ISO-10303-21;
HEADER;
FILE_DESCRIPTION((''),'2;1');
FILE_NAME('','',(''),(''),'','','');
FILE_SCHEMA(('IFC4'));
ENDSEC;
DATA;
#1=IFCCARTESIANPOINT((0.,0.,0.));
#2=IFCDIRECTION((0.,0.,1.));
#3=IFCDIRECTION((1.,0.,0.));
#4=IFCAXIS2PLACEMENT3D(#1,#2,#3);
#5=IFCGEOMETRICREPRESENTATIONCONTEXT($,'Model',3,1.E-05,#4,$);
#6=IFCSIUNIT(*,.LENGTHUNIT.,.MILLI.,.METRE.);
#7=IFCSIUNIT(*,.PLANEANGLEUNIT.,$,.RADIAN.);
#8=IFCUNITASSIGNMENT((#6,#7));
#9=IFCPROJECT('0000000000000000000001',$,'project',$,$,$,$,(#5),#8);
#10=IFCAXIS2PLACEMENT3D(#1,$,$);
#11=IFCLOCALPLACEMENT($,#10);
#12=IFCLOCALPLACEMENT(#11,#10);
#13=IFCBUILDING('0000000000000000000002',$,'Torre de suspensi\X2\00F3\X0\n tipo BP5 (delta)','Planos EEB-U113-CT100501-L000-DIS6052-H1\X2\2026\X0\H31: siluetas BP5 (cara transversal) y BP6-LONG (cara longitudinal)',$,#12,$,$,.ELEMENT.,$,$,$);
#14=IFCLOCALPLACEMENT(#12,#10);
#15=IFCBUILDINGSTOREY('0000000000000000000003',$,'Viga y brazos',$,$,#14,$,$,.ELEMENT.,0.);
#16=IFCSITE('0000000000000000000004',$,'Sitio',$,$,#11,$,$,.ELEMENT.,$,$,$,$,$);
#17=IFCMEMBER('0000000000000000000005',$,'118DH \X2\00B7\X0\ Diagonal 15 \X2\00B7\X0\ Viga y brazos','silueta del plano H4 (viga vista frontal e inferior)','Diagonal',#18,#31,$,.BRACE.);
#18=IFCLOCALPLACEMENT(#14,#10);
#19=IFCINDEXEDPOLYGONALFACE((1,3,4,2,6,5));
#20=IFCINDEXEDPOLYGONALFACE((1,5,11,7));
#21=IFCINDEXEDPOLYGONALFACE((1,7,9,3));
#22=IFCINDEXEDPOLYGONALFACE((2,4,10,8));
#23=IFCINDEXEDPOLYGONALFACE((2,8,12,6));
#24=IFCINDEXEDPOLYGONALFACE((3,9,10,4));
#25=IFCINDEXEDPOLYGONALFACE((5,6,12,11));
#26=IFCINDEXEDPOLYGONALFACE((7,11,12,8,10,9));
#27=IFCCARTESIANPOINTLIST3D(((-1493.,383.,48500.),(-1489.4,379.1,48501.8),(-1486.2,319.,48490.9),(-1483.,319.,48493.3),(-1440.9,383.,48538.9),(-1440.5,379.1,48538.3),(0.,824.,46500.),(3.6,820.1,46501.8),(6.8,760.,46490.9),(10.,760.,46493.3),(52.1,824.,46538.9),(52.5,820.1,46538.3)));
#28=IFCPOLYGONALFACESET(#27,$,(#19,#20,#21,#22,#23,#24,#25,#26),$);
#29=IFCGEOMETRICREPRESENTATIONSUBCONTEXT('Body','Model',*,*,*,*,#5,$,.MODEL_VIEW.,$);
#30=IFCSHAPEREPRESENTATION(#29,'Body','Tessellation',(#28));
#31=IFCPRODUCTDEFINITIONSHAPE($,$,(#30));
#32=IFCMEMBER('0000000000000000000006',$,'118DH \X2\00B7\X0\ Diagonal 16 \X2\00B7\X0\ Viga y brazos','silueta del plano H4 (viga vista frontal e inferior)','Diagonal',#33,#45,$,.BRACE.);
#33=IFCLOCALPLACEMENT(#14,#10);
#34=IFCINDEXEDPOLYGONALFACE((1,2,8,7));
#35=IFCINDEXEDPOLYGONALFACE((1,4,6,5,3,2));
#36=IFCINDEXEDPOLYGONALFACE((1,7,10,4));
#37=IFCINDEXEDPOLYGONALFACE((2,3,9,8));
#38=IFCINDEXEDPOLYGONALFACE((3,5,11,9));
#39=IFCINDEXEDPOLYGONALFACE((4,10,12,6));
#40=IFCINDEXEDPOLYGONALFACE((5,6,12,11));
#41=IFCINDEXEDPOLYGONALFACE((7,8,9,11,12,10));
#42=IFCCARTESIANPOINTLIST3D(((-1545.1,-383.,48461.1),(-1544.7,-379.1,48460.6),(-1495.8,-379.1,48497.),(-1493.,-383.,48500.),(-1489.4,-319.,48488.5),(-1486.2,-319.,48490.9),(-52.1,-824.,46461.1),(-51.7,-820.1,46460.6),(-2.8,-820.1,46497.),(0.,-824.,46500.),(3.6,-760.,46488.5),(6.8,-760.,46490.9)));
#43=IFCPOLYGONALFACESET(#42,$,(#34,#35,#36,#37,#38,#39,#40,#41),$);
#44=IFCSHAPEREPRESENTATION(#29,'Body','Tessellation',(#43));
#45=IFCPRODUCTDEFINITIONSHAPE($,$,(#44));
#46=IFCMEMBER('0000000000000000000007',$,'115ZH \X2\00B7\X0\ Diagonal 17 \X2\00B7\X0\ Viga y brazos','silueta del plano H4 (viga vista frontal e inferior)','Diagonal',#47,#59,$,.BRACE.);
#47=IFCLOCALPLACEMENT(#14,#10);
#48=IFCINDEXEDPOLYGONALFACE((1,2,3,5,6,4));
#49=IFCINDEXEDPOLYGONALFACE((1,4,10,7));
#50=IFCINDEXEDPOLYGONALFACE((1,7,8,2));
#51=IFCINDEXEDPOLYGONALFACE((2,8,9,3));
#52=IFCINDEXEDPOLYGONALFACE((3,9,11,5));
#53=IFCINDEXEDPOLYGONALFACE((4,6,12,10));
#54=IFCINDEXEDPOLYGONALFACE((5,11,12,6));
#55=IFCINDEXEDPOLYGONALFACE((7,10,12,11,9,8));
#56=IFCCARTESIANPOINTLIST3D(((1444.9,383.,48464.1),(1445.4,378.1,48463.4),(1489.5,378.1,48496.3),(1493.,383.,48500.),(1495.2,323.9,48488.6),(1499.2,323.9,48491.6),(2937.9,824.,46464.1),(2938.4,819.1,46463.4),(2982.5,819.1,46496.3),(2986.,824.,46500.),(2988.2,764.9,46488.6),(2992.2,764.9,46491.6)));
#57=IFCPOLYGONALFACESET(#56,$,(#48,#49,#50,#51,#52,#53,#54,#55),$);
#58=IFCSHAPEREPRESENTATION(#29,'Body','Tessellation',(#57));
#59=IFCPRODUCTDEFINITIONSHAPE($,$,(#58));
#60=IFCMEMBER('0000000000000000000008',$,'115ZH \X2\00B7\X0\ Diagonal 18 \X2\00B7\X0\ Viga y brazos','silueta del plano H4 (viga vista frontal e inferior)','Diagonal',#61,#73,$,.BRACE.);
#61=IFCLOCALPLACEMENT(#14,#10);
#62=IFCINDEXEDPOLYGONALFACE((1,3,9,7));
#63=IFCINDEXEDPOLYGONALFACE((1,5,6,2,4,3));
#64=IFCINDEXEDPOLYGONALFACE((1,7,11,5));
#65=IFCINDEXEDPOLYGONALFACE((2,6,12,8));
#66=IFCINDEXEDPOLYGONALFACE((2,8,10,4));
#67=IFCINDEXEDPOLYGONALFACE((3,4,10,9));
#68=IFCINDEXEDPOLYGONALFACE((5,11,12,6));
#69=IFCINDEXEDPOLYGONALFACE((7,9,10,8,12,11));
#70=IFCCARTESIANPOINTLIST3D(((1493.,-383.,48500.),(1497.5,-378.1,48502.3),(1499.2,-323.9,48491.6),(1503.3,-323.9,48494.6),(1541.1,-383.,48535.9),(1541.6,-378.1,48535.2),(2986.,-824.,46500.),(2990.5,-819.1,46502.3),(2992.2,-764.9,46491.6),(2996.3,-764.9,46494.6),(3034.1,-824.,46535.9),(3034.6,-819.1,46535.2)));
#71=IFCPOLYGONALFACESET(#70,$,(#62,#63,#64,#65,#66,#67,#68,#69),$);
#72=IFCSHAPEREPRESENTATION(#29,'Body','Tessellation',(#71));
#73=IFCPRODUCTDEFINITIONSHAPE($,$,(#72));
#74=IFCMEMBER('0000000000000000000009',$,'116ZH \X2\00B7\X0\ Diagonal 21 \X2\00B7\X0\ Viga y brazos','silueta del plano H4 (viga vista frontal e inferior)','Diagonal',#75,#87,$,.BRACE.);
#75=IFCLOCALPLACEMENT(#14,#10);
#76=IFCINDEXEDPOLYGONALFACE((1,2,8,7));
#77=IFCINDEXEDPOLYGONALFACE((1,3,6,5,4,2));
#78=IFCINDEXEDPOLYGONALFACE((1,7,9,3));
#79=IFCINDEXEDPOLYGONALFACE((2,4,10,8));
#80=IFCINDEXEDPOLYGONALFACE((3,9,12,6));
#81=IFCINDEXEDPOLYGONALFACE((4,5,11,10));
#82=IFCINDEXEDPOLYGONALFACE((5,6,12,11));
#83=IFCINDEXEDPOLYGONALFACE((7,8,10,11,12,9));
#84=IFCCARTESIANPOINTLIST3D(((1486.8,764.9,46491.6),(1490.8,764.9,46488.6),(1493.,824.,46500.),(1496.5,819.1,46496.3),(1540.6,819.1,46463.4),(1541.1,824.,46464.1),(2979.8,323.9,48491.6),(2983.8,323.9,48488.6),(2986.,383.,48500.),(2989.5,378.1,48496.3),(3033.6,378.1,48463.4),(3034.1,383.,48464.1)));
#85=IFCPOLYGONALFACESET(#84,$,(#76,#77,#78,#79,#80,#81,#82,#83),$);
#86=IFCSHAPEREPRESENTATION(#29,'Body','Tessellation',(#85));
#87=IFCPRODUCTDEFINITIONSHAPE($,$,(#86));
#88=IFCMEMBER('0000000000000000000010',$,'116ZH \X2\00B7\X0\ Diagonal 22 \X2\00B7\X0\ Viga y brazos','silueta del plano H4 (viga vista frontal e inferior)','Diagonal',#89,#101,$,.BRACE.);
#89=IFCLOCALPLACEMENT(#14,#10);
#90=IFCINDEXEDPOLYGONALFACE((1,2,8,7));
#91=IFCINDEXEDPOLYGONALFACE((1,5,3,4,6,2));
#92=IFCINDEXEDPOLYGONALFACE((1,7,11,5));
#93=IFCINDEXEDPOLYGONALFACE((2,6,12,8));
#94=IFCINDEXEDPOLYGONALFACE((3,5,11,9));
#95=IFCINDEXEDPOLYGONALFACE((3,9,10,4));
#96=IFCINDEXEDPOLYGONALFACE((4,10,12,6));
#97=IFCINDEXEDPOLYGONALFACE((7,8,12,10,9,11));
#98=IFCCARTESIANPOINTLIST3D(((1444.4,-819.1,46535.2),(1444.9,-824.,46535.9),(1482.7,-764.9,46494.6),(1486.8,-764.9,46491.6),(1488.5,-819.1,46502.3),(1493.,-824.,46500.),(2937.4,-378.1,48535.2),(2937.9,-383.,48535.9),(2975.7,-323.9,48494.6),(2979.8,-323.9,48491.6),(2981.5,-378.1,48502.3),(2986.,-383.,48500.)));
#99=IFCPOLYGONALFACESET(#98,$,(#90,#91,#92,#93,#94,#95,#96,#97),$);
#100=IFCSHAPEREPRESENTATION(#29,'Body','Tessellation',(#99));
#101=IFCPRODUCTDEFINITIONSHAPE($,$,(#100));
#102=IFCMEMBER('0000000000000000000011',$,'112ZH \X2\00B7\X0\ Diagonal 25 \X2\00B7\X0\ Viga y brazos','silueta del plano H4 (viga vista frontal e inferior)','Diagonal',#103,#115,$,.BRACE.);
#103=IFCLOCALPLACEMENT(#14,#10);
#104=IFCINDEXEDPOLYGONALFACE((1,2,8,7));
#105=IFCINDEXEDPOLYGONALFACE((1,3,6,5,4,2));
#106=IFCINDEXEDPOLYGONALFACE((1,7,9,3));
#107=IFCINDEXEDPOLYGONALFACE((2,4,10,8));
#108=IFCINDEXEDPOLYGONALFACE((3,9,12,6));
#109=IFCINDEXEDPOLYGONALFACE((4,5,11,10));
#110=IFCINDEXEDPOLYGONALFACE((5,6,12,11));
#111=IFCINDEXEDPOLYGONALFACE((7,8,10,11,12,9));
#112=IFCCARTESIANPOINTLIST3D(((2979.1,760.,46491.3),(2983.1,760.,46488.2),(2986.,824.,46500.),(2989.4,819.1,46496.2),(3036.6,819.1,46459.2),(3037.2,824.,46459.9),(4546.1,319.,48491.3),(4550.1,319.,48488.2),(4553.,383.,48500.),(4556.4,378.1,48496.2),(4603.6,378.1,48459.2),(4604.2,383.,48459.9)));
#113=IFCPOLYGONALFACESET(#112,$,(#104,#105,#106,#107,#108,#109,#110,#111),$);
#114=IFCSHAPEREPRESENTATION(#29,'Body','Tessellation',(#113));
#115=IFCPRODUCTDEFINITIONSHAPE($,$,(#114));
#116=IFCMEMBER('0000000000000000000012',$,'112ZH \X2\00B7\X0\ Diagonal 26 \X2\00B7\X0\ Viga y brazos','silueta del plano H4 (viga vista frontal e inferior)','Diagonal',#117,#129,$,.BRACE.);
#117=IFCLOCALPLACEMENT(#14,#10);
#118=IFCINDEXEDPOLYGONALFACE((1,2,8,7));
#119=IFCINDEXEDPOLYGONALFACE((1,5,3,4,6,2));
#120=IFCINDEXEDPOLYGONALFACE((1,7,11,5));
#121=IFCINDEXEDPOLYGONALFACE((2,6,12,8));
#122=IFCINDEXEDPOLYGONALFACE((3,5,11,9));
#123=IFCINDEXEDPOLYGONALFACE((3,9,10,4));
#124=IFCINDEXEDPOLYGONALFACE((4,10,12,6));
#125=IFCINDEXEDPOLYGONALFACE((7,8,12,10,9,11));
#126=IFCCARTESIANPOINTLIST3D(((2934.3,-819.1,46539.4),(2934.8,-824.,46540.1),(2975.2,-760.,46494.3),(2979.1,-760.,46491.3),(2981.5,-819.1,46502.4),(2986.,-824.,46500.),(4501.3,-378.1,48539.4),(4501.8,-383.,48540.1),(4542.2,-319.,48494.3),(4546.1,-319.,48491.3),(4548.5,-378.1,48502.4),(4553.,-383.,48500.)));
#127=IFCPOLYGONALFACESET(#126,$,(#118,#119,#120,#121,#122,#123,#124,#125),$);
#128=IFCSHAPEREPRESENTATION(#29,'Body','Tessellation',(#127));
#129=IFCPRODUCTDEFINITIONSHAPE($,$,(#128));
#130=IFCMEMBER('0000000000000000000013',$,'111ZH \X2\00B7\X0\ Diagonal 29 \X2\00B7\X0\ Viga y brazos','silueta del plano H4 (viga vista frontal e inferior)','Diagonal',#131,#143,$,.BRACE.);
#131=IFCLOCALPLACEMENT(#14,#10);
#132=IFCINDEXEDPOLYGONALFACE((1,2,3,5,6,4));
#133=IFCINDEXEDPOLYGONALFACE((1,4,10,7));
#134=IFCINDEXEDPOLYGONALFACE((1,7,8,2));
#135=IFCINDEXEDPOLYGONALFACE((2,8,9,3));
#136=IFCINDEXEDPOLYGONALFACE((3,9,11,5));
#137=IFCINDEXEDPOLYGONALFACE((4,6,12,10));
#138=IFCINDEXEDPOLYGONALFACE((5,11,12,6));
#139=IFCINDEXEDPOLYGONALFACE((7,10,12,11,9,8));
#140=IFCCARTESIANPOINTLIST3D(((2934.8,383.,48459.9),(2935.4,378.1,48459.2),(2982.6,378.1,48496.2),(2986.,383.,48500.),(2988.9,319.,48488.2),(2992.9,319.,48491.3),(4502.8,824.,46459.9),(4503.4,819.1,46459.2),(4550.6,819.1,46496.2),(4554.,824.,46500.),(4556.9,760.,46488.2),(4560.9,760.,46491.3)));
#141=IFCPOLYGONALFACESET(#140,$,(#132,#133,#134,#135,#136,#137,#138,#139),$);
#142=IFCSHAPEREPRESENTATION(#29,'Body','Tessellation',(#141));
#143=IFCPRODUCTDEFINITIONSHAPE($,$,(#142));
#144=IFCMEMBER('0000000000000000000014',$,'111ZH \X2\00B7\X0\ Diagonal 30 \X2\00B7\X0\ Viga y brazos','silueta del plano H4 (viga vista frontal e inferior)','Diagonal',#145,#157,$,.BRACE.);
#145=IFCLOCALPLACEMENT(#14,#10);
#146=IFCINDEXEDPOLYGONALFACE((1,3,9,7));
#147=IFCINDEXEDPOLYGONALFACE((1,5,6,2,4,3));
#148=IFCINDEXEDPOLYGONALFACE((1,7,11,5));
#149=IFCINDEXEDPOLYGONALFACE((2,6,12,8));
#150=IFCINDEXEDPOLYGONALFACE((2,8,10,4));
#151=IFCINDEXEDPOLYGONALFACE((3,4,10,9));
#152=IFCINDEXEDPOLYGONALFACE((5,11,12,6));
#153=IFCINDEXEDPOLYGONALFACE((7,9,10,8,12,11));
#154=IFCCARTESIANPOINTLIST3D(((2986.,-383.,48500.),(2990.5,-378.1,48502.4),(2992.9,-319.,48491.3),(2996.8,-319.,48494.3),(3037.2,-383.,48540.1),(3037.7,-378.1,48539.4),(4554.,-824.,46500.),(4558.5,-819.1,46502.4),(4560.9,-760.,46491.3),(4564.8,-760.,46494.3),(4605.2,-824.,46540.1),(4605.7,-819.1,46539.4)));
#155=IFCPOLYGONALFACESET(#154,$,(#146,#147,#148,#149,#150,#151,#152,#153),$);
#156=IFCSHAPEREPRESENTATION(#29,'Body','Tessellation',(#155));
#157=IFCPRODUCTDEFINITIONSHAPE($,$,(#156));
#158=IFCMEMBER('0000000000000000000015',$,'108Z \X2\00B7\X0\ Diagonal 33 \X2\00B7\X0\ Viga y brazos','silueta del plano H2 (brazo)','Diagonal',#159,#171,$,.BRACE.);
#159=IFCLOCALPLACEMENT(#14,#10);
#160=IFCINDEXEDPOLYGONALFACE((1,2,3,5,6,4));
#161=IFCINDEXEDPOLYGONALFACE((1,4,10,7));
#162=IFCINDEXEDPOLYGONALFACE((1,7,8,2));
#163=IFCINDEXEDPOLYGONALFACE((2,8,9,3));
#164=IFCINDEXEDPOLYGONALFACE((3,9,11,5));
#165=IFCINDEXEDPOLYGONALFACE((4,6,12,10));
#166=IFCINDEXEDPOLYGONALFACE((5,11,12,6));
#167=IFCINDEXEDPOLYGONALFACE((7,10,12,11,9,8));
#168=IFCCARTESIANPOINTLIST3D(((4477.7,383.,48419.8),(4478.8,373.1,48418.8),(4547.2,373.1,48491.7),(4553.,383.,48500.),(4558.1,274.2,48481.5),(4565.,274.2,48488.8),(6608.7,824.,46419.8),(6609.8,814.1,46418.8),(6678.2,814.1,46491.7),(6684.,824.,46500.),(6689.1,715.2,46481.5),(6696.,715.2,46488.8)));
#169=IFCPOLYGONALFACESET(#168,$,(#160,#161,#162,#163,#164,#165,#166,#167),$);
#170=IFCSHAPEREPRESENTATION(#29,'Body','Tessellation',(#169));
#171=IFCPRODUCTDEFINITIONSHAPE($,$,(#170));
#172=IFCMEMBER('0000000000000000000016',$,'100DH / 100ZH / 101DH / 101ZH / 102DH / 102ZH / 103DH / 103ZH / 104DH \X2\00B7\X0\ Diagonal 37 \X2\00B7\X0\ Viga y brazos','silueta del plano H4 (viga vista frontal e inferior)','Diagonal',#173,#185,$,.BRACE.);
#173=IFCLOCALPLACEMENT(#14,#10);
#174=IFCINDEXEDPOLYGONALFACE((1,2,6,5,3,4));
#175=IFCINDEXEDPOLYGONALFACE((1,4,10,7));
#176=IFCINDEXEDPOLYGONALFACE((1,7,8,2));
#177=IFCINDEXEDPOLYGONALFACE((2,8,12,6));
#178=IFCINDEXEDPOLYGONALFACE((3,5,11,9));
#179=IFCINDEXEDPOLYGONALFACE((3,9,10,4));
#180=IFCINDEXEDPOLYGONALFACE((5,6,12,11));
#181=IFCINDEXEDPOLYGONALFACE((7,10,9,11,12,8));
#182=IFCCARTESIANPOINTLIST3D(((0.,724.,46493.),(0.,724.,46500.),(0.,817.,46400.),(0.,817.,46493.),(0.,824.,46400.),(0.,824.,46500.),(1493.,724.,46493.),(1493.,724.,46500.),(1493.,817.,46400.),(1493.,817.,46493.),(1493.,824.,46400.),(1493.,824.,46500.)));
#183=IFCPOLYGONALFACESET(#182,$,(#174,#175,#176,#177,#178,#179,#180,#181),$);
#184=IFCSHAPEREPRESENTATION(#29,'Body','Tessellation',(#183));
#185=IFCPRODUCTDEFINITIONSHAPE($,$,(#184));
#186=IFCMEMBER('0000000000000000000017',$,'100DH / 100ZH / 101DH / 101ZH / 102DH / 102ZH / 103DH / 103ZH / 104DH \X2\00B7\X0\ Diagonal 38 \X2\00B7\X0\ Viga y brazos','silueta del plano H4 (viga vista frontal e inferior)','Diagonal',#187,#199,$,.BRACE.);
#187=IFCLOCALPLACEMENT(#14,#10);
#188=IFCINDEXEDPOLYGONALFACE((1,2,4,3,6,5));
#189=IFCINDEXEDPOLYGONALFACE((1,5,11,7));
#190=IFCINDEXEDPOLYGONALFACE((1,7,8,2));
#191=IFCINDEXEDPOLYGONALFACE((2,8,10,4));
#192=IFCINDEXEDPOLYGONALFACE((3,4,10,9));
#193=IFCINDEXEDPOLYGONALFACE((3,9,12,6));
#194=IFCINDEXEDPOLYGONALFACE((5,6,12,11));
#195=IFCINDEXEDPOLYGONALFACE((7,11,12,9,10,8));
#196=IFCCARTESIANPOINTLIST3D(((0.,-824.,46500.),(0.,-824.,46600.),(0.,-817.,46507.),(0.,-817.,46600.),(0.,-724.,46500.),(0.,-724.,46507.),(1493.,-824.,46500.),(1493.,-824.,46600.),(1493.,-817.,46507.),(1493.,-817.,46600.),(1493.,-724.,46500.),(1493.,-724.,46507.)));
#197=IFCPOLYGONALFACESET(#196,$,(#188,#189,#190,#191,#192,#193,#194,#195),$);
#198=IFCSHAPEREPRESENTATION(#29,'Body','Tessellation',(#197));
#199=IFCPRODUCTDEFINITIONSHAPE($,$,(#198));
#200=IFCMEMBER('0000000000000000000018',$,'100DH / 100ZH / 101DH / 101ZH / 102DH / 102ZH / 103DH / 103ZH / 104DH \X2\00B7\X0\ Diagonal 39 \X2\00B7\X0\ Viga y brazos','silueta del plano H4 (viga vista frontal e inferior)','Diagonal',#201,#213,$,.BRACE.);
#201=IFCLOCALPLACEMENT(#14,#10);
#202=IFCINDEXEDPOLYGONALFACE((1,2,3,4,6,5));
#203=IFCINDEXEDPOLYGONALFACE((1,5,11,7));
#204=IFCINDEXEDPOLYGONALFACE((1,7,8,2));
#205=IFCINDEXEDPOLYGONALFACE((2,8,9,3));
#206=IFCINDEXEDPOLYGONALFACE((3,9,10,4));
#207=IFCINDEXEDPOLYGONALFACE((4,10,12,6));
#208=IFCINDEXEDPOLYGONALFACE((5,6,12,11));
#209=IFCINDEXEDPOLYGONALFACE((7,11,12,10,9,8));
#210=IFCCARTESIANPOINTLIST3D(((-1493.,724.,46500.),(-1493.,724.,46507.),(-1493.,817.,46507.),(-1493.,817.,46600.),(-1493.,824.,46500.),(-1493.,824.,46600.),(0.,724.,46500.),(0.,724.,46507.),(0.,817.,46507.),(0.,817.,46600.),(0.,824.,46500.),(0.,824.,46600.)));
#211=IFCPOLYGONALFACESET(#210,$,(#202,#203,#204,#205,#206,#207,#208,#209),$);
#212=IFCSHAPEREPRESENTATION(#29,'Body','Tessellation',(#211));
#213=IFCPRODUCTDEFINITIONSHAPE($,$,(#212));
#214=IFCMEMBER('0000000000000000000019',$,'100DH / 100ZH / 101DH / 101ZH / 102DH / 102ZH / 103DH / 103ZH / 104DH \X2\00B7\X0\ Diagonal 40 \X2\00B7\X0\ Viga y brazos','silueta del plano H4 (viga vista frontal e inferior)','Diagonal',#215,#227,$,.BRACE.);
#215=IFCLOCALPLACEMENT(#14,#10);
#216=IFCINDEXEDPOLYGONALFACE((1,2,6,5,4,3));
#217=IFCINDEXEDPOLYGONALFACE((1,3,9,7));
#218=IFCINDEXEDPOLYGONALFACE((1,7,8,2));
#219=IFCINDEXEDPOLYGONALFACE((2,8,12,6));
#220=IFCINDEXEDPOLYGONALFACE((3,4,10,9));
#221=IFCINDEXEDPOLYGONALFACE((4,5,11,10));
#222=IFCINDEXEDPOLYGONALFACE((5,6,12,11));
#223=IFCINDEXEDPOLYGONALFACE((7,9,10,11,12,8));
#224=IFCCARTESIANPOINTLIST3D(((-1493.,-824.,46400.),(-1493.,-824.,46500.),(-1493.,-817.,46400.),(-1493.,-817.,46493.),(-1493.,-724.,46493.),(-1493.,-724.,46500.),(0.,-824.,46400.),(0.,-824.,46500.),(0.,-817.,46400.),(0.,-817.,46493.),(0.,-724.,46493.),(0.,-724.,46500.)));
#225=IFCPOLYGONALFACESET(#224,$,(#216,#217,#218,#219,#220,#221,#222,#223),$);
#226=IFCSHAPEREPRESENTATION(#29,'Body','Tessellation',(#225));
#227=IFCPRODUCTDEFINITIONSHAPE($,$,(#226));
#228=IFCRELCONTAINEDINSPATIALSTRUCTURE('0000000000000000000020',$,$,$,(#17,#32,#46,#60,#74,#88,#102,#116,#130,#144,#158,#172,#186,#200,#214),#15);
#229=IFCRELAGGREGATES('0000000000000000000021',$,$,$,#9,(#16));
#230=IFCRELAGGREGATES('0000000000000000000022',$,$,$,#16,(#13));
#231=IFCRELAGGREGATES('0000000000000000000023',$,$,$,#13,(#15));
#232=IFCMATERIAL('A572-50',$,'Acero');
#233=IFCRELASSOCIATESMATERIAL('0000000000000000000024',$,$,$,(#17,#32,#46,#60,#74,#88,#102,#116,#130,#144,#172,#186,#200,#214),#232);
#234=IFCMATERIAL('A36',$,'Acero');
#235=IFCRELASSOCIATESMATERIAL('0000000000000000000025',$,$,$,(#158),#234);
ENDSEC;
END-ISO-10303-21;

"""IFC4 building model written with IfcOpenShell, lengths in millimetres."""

from ifc_helpers import new_model, si_unit, frame, frame_2d, origin, origin_with_axes, place, context, subcontext, project, spatial, l_section, extrude, material, element, save


model = new_model("IFC4")

# Units and contexts
model_context = context("Model", 3, precision=1e-05, world=origin_with_axes())
body_context = subcontext(model_context, "Body", "Model", "MODEL_VIEW")
ifc_project = project(units=[si_unit("LENGTHUNIT", "METRE", prefix="MILLI"), si_unit("PLANEANGLEUNIT", "RADIAN")], contexts=[model_context])

# Site, building, storey
site_placement = place(None, origin())
site = spatial("IfcSite", under=ifc_project, at=site_placement, Name="Sitio", CompositionType="ELEMENT")
building_placement = place(site_placement, origin())
building = spatial("IfcBuilding", under=site, at=building_placement, Name="Torre de suspensión tipo BP5 (delta)", Description="Planos EEB-U113-CT100501-L000-DIS6052-H1…H31: siluetas BP5 (cara transversal) y BP6-LONG (cara longitudinal)", CompositionType="ELEMENT")
storey_placement = place(building_placement, origin())
storey = spatial("IfcBuildingStorey", under=building, at=storey_placement, Name="Viga y brazos", CompositionType="ELEMENT", Elevation=0.0)

# Members
ifc_material_1 = material(Name="A572-50", Category="Acero")
for number, where, z_axis, x_axis, name in (
    (1, (0.0, 824.0, 46500.0), (-0.589078, -0.174001, 0.78912), (0.104088, -0.984745, -0.139435), "118DH · Diagonal 15 · Viga y brazos"),
    (2, (0.0, -824.0, 46500.0), (-0.589078, 0.174001, 0.78912), (0.104088, 0.984745, -0.139435), "118DH · Diagonal 16 · Viga y brazos"),
):
    element("IfcMember", number, at=place(storey_placement, frame(where, z_axis=z_axis, x_axis=x_axis)), inside=storey, material=ifc_material_1, Name=name, Description="silueta del plano H4 (viga vista frontal e inferior)", ObjectType="Diagonal", PredefinedType="BRACE", context=body_context, shape_type="SweptSolid", body=[
        extrude(l_section(Depth=65.0, Width=65.0, Thickness=4.0, at=frame_2d((32.5, 32.5))), None, (0.0, 0.0, 1.0), 2534.5),
    ])
for number, where, z_axis, x_axis, name in (
    (3, (1493.0, 383.0, 48500.0), (0.589078, 0.174001, -0.78912), (0.104088, -0.984745, -0.139435), "115ZH · Diagonal 17 · Viga y brazos"),
    (4, (1493.0, -383.0, 48500.0), (0.589078, -0.174001, -0.78912), (0.104088, 0.984745, -0.139435), "115ZH · Diagonal 18 · Viga y brazos"),
    (5, (1493.0, 824.0, 46500.0), (0.589078, -0.174001, 0.78912), (-0.104088, -0.984745, -0.139435), "116ZH · Diagonal 21 · Viga y brazos"),
    (6, (1493.0, -824.0, 46500.0), (0.589078, 0.174001, 0.78912), (-0.104088, 0.984745, -0.139435), "116ZH · Diagonal 22 · Viga y brazos"),
):
    element("IfcMember", number, at=place(storey_placement, frame(where, z_axis=z_axis, x_axis=x_axis)), inside=storey, material=ifc_material_1, Name=name, Description="silueta del plano H4 (viga vista frontal e inferior)", ObjectType="Diagonal", PredefinedType="BRACE", context=body_context, shape_type="SweptSolid", body=[
        extrude(l_section(Depth=60.0, Width=60.0, Thickness=5.0, at=frame_2d((30.0, 30.0))), None, (0.0, 0.0, 1.0), 2534.5),
    ])
for number, where, z_axis, x_axis, name in (
    (7, (2986.0, 824.0, 46500.0), (0.607658, -0.171013, 0.775568), (-0.105471, -0.985269, -0.134615), "112ZH · Diagonal 25 · Viga y brazos"),
    (8, (2986.0, -824.0, 46500.0), (0.607658, 0.171013, 0.775568), (-0.105471, 0.985269, -0.134615), "112ZH · Diagonal 26 · Viga y brazos"),
):
    element("IfcMember", number, at=place(storey_placement, frame(where, z_axis=z_axis, x_axis=x_axis)), inside=storey, material=ifc_material_1, Name=name, Description="silueta del plano H4 (viga vista frontal e inferior)", ObjectType="Diagonal", PredefinedType="BRACE", context=body_context, shape_type="SweptSolid", body=[
        extrude(l_section(Depth=65.0, Width=65.0, Thickness=5.0, at=frame_2d((32.5, 32.5))), None, (0.0, 0.0, 1.0), 2578.8),
    ])
for number, where, z_axis, x_axis, name in (
    (9, (2986.0, 383.0, 48500.0), (0.607902, 0.170973, -0.775386), (0.105488, -0.985276, -0.134551), "111ZH · Diagonal 29 · Viga y brazos"),
    (10, (2986.0, -383.0, 48500.0), (0.607902, -0.170973, -0.775386), (0.105488, 0.985276, -0.134551), "111ZH · Diagonal 30 · Viga y brazos"),
):
    element("IfcMember", number, at=place(storey_placement, frame(where, z_axis=z_axis, x_axis=x_axis)), inside=storey, material=ifc_material_1, Name=name, Description="silueta del plano H4 (viga vista frontal e inferior)", ObjectType="Diagonal", PredefinedType="BRACE", context=body_context, shape_type="SweptSolid", body=[
        extrude(l_section(Depth=65.0, Width=65.0, Thickness=5.0, at=frame_2d((32.5, 32.5))), None, (0.0, 0.0, 1.0), 2579.4),
    ])
ifc_material_2 = material(Name="A36", Category="Acero")
member_placement = place(storey_placement, frame((4553.0, 383.0, 48500.0), z_axis=(0.721001, 0.149208, -0.676679), x_axis=(0.108797, -0.988806, -0.102109)))
element("IfcMember", 11, at=member_placement, inside=storey, material=ifc_material_2, Name="108Z · Diagonal 33 · Viga y brazos", Description="silueta del plano H2 (brazo)", ObjectType="Diagonal", PredefinedType="BRACE", context=body_context, shape_type="SweptSolid", body=[
    extrude(l_section(Depth=110.0, Width=110.0, Thickness=10.0, at=frame_2d((55.0, 55.0))), None, (0.0, 0.0, 1.0), 2955.6),
])
for number, where, z_axis, x_axis, name in (
    (12, (0.0, 824.0, 46500.0), (1.0, 0.0, 0.0), (0.0, -1.0, 0.0), "100DH / 100ZH / 101DH / 101ZH / 102DH / 102ZH / 103DH / 103ZH / 104DH · Diagonal 37 · Viga y brazos"),
    (13, (0.0, -824.0, 46500.0), (1.0, 0.0, 0.0), (0.0, 1.0, 0.0), "100DH / 100ZH / 101DH / 101ZH / 102DH / 102ZH / 103DH / 103ZH / 104DH · Diagonal 38 · Viga y brazos"),
    (14, (0.0, 824.0, 46500.0), (-1.0, 0.0, 0.0), (0.0, -1.0, 0.0), "100DH / 100ZH / 101DH / 101ZH / 102DH / 102ZH / 103DH / 103ZH / 104DH · Diagonal 39 · Viga y brazos"),
    (15, (0.0, -824.0, 46500.0), (-1.0, 0.0, 0.0), (0.0, 1.0, 0.0), "100DH / 100ZH / 101DH / 101ZH / 102DH / 102ZH / 103DH / 103ZH / 104DH · Diagonal 40 · Viga y brazos"),
):
    element("IfcMember", number, at=place(storey_placement, frame(where, z_axis=z_axis, x_axis=x_axis)), inside=storey, material=ifc_material_1, Name=name, Description="silueta del plano H4 (viga vista frontal e inferior)", ObjectType="Diagonal", PredefinedType="BRACE", context=body_context, shape_type="SweptSolid", body=[
        extrude(l_section(Depth=100.0, Width=100.0, Thickness=7.0, at=frame_2d((50.0, 50.0))), None, (0.0, 0.0, 1.0), 1493.0),
    ])

save(model, "model.ifc")
